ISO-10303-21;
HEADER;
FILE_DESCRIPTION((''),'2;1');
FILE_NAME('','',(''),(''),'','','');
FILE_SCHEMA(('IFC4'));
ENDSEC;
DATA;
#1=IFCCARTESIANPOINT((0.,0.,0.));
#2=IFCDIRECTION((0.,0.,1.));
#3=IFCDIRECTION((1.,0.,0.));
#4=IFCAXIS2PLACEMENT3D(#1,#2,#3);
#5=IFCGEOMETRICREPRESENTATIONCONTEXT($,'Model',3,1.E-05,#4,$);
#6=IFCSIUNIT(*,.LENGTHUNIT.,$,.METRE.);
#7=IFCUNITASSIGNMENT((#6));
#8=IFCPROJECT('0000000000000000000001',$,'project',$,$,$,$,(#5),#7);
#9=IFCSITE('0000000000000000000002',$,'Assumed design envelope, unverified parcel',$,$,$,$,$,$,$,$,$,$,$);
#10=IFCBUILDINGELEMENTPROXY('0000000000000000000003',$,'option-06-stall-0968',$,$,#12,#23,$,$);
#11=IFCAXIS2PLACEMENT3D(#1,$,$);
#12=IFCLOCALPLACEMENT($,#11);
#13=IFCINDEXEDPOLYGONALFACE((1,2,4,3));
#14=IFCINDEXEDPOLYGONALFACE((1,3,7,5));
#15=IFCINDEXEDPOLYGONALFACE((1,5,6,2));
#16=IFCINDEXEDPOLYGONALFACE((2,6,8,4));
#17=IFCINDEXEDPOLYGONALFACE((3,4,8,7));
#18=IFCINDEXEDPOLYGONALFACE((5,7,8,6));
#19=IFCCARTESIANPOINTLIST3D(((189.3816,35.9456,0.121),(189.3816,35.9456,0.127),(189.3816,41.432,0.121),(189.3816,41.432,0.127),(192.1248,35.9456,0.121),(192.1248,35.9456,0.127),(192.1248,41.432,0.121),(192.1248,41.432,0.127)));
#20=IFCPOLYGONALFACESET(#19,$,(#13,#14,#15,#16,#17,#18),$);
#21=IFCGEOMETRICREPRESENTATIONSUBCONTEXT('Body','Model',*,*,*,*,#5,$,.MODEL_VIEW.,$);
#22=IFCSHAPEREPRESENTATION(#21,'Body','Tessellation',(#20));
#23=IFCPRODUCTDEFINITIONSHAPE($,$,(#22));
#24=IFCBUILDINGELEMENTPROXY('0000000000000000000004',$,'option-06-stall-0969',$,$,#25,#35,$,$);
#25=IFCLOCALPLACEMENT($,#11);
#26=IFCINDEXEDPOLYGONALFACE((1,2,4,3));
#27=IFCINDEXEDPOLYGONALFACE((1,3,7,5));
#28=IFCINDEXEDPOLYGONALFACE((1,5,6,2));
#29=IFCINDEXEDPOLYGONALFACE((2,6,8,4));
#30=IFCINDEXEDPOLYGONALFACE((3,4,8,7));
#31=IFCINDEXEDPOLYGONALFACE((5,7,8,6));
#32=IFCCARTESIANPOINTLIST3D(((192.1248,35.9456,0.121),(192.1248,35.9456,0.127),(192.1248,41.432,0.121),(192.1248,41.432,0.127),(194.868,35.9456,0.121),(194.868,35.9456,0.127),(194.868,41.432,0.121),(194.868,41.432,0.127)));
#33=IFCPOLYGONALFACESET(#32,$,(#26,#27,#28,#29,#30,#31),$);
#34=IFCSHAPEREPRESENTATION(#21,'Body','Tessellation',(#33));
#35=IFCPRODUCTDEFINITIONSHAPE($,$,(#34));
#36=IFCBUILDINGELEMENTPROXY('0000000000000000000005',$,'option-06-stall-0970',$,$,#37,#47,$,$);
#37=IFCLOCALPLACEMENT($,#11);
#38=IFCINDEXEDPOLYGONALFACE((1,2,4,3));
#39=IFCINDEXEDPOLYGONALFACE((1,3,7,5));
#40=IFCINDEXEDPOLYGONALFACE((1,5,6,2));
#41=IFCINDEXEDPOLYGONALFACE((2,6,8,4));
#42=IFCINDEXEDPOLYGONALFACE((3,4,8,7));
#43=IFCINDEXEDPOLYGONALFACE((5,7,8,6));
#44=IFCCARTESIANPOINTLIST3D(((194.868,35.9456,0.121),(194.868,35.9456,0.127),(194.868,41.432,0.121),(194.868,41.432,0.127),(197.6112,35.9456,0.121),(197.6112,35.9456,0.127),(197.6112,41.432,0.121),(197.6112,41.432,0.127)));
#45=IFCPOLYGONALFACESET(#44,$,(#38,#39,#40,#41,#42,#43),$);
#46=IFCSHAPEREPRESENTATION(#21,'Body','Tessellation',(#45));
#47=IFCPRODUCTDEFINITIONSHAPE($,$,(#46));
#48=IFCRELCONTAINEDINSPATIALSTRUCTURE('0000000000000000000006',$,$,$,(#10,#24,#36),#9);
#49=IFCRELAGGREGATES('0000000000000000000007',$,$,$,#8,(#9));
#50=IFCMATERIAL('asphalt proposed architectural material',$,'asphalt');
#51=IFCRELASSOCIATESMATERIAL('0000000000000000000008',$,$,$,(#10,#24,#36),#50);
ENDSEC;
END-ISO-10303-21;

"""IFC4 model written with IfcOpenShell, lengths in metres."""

from ifc_helpers import new_model, si_unit, frame, origin_with_axes, place, context, subcontext, project, spatial, rectangle, extrude, material, element, save


model = new_model("IFC4")

# Units and contexts
model_context = context("Model", 3, precision=1e-05, world=origin_with_axes())
body_context = subcontext(model_context, "Body", "Model", "MODEL_VIEW")
ifc_project = project(units=[si_unit("LENGTHUNIT", "METRE")], contexts=[model_context])

# Site
site = spatial("IfcSite", under=ifc_project, Name="Assumed design envelope, unverified parcel")

# Building element proxies
ifc_material = material(Name="asphalt proposed architectural material", Category="asphalt")
for number, where, z_axis, x_axis, name in (
    (1, (190.7532, 38.6888, 0.121), (0.0, 0.0, 1.0), (1.0, 0.0, 0.0), "option-06-stall-0968"),
    (2, (193.4964, 38.6888, 0.121), (0.0, 0.0, 1.0), (1.0, 0.0, 0.0), "option-06-stall-0969"),
    (3, (196.2396, 38.6888, 0.121), (0.0, 0.0, 1.0), (1.0, 0.0, 0.0), "option-06-stall-0970"),
):
    element("IfcBuildingElementProxy", number, at=place(None, frame(where, z_axis=z_axis, x_axis=x_axis)), inside=site, material=ifc_material, Name=name, context=body_context, shape_type="SweptSolid", body=[
        extrude(rectangle(XDim=2.7432, YDim=5.4864), origin_with_axes(), (0.0, 0.0, 1.0), 0.006),
    ])

save(model, "model.ifc")
